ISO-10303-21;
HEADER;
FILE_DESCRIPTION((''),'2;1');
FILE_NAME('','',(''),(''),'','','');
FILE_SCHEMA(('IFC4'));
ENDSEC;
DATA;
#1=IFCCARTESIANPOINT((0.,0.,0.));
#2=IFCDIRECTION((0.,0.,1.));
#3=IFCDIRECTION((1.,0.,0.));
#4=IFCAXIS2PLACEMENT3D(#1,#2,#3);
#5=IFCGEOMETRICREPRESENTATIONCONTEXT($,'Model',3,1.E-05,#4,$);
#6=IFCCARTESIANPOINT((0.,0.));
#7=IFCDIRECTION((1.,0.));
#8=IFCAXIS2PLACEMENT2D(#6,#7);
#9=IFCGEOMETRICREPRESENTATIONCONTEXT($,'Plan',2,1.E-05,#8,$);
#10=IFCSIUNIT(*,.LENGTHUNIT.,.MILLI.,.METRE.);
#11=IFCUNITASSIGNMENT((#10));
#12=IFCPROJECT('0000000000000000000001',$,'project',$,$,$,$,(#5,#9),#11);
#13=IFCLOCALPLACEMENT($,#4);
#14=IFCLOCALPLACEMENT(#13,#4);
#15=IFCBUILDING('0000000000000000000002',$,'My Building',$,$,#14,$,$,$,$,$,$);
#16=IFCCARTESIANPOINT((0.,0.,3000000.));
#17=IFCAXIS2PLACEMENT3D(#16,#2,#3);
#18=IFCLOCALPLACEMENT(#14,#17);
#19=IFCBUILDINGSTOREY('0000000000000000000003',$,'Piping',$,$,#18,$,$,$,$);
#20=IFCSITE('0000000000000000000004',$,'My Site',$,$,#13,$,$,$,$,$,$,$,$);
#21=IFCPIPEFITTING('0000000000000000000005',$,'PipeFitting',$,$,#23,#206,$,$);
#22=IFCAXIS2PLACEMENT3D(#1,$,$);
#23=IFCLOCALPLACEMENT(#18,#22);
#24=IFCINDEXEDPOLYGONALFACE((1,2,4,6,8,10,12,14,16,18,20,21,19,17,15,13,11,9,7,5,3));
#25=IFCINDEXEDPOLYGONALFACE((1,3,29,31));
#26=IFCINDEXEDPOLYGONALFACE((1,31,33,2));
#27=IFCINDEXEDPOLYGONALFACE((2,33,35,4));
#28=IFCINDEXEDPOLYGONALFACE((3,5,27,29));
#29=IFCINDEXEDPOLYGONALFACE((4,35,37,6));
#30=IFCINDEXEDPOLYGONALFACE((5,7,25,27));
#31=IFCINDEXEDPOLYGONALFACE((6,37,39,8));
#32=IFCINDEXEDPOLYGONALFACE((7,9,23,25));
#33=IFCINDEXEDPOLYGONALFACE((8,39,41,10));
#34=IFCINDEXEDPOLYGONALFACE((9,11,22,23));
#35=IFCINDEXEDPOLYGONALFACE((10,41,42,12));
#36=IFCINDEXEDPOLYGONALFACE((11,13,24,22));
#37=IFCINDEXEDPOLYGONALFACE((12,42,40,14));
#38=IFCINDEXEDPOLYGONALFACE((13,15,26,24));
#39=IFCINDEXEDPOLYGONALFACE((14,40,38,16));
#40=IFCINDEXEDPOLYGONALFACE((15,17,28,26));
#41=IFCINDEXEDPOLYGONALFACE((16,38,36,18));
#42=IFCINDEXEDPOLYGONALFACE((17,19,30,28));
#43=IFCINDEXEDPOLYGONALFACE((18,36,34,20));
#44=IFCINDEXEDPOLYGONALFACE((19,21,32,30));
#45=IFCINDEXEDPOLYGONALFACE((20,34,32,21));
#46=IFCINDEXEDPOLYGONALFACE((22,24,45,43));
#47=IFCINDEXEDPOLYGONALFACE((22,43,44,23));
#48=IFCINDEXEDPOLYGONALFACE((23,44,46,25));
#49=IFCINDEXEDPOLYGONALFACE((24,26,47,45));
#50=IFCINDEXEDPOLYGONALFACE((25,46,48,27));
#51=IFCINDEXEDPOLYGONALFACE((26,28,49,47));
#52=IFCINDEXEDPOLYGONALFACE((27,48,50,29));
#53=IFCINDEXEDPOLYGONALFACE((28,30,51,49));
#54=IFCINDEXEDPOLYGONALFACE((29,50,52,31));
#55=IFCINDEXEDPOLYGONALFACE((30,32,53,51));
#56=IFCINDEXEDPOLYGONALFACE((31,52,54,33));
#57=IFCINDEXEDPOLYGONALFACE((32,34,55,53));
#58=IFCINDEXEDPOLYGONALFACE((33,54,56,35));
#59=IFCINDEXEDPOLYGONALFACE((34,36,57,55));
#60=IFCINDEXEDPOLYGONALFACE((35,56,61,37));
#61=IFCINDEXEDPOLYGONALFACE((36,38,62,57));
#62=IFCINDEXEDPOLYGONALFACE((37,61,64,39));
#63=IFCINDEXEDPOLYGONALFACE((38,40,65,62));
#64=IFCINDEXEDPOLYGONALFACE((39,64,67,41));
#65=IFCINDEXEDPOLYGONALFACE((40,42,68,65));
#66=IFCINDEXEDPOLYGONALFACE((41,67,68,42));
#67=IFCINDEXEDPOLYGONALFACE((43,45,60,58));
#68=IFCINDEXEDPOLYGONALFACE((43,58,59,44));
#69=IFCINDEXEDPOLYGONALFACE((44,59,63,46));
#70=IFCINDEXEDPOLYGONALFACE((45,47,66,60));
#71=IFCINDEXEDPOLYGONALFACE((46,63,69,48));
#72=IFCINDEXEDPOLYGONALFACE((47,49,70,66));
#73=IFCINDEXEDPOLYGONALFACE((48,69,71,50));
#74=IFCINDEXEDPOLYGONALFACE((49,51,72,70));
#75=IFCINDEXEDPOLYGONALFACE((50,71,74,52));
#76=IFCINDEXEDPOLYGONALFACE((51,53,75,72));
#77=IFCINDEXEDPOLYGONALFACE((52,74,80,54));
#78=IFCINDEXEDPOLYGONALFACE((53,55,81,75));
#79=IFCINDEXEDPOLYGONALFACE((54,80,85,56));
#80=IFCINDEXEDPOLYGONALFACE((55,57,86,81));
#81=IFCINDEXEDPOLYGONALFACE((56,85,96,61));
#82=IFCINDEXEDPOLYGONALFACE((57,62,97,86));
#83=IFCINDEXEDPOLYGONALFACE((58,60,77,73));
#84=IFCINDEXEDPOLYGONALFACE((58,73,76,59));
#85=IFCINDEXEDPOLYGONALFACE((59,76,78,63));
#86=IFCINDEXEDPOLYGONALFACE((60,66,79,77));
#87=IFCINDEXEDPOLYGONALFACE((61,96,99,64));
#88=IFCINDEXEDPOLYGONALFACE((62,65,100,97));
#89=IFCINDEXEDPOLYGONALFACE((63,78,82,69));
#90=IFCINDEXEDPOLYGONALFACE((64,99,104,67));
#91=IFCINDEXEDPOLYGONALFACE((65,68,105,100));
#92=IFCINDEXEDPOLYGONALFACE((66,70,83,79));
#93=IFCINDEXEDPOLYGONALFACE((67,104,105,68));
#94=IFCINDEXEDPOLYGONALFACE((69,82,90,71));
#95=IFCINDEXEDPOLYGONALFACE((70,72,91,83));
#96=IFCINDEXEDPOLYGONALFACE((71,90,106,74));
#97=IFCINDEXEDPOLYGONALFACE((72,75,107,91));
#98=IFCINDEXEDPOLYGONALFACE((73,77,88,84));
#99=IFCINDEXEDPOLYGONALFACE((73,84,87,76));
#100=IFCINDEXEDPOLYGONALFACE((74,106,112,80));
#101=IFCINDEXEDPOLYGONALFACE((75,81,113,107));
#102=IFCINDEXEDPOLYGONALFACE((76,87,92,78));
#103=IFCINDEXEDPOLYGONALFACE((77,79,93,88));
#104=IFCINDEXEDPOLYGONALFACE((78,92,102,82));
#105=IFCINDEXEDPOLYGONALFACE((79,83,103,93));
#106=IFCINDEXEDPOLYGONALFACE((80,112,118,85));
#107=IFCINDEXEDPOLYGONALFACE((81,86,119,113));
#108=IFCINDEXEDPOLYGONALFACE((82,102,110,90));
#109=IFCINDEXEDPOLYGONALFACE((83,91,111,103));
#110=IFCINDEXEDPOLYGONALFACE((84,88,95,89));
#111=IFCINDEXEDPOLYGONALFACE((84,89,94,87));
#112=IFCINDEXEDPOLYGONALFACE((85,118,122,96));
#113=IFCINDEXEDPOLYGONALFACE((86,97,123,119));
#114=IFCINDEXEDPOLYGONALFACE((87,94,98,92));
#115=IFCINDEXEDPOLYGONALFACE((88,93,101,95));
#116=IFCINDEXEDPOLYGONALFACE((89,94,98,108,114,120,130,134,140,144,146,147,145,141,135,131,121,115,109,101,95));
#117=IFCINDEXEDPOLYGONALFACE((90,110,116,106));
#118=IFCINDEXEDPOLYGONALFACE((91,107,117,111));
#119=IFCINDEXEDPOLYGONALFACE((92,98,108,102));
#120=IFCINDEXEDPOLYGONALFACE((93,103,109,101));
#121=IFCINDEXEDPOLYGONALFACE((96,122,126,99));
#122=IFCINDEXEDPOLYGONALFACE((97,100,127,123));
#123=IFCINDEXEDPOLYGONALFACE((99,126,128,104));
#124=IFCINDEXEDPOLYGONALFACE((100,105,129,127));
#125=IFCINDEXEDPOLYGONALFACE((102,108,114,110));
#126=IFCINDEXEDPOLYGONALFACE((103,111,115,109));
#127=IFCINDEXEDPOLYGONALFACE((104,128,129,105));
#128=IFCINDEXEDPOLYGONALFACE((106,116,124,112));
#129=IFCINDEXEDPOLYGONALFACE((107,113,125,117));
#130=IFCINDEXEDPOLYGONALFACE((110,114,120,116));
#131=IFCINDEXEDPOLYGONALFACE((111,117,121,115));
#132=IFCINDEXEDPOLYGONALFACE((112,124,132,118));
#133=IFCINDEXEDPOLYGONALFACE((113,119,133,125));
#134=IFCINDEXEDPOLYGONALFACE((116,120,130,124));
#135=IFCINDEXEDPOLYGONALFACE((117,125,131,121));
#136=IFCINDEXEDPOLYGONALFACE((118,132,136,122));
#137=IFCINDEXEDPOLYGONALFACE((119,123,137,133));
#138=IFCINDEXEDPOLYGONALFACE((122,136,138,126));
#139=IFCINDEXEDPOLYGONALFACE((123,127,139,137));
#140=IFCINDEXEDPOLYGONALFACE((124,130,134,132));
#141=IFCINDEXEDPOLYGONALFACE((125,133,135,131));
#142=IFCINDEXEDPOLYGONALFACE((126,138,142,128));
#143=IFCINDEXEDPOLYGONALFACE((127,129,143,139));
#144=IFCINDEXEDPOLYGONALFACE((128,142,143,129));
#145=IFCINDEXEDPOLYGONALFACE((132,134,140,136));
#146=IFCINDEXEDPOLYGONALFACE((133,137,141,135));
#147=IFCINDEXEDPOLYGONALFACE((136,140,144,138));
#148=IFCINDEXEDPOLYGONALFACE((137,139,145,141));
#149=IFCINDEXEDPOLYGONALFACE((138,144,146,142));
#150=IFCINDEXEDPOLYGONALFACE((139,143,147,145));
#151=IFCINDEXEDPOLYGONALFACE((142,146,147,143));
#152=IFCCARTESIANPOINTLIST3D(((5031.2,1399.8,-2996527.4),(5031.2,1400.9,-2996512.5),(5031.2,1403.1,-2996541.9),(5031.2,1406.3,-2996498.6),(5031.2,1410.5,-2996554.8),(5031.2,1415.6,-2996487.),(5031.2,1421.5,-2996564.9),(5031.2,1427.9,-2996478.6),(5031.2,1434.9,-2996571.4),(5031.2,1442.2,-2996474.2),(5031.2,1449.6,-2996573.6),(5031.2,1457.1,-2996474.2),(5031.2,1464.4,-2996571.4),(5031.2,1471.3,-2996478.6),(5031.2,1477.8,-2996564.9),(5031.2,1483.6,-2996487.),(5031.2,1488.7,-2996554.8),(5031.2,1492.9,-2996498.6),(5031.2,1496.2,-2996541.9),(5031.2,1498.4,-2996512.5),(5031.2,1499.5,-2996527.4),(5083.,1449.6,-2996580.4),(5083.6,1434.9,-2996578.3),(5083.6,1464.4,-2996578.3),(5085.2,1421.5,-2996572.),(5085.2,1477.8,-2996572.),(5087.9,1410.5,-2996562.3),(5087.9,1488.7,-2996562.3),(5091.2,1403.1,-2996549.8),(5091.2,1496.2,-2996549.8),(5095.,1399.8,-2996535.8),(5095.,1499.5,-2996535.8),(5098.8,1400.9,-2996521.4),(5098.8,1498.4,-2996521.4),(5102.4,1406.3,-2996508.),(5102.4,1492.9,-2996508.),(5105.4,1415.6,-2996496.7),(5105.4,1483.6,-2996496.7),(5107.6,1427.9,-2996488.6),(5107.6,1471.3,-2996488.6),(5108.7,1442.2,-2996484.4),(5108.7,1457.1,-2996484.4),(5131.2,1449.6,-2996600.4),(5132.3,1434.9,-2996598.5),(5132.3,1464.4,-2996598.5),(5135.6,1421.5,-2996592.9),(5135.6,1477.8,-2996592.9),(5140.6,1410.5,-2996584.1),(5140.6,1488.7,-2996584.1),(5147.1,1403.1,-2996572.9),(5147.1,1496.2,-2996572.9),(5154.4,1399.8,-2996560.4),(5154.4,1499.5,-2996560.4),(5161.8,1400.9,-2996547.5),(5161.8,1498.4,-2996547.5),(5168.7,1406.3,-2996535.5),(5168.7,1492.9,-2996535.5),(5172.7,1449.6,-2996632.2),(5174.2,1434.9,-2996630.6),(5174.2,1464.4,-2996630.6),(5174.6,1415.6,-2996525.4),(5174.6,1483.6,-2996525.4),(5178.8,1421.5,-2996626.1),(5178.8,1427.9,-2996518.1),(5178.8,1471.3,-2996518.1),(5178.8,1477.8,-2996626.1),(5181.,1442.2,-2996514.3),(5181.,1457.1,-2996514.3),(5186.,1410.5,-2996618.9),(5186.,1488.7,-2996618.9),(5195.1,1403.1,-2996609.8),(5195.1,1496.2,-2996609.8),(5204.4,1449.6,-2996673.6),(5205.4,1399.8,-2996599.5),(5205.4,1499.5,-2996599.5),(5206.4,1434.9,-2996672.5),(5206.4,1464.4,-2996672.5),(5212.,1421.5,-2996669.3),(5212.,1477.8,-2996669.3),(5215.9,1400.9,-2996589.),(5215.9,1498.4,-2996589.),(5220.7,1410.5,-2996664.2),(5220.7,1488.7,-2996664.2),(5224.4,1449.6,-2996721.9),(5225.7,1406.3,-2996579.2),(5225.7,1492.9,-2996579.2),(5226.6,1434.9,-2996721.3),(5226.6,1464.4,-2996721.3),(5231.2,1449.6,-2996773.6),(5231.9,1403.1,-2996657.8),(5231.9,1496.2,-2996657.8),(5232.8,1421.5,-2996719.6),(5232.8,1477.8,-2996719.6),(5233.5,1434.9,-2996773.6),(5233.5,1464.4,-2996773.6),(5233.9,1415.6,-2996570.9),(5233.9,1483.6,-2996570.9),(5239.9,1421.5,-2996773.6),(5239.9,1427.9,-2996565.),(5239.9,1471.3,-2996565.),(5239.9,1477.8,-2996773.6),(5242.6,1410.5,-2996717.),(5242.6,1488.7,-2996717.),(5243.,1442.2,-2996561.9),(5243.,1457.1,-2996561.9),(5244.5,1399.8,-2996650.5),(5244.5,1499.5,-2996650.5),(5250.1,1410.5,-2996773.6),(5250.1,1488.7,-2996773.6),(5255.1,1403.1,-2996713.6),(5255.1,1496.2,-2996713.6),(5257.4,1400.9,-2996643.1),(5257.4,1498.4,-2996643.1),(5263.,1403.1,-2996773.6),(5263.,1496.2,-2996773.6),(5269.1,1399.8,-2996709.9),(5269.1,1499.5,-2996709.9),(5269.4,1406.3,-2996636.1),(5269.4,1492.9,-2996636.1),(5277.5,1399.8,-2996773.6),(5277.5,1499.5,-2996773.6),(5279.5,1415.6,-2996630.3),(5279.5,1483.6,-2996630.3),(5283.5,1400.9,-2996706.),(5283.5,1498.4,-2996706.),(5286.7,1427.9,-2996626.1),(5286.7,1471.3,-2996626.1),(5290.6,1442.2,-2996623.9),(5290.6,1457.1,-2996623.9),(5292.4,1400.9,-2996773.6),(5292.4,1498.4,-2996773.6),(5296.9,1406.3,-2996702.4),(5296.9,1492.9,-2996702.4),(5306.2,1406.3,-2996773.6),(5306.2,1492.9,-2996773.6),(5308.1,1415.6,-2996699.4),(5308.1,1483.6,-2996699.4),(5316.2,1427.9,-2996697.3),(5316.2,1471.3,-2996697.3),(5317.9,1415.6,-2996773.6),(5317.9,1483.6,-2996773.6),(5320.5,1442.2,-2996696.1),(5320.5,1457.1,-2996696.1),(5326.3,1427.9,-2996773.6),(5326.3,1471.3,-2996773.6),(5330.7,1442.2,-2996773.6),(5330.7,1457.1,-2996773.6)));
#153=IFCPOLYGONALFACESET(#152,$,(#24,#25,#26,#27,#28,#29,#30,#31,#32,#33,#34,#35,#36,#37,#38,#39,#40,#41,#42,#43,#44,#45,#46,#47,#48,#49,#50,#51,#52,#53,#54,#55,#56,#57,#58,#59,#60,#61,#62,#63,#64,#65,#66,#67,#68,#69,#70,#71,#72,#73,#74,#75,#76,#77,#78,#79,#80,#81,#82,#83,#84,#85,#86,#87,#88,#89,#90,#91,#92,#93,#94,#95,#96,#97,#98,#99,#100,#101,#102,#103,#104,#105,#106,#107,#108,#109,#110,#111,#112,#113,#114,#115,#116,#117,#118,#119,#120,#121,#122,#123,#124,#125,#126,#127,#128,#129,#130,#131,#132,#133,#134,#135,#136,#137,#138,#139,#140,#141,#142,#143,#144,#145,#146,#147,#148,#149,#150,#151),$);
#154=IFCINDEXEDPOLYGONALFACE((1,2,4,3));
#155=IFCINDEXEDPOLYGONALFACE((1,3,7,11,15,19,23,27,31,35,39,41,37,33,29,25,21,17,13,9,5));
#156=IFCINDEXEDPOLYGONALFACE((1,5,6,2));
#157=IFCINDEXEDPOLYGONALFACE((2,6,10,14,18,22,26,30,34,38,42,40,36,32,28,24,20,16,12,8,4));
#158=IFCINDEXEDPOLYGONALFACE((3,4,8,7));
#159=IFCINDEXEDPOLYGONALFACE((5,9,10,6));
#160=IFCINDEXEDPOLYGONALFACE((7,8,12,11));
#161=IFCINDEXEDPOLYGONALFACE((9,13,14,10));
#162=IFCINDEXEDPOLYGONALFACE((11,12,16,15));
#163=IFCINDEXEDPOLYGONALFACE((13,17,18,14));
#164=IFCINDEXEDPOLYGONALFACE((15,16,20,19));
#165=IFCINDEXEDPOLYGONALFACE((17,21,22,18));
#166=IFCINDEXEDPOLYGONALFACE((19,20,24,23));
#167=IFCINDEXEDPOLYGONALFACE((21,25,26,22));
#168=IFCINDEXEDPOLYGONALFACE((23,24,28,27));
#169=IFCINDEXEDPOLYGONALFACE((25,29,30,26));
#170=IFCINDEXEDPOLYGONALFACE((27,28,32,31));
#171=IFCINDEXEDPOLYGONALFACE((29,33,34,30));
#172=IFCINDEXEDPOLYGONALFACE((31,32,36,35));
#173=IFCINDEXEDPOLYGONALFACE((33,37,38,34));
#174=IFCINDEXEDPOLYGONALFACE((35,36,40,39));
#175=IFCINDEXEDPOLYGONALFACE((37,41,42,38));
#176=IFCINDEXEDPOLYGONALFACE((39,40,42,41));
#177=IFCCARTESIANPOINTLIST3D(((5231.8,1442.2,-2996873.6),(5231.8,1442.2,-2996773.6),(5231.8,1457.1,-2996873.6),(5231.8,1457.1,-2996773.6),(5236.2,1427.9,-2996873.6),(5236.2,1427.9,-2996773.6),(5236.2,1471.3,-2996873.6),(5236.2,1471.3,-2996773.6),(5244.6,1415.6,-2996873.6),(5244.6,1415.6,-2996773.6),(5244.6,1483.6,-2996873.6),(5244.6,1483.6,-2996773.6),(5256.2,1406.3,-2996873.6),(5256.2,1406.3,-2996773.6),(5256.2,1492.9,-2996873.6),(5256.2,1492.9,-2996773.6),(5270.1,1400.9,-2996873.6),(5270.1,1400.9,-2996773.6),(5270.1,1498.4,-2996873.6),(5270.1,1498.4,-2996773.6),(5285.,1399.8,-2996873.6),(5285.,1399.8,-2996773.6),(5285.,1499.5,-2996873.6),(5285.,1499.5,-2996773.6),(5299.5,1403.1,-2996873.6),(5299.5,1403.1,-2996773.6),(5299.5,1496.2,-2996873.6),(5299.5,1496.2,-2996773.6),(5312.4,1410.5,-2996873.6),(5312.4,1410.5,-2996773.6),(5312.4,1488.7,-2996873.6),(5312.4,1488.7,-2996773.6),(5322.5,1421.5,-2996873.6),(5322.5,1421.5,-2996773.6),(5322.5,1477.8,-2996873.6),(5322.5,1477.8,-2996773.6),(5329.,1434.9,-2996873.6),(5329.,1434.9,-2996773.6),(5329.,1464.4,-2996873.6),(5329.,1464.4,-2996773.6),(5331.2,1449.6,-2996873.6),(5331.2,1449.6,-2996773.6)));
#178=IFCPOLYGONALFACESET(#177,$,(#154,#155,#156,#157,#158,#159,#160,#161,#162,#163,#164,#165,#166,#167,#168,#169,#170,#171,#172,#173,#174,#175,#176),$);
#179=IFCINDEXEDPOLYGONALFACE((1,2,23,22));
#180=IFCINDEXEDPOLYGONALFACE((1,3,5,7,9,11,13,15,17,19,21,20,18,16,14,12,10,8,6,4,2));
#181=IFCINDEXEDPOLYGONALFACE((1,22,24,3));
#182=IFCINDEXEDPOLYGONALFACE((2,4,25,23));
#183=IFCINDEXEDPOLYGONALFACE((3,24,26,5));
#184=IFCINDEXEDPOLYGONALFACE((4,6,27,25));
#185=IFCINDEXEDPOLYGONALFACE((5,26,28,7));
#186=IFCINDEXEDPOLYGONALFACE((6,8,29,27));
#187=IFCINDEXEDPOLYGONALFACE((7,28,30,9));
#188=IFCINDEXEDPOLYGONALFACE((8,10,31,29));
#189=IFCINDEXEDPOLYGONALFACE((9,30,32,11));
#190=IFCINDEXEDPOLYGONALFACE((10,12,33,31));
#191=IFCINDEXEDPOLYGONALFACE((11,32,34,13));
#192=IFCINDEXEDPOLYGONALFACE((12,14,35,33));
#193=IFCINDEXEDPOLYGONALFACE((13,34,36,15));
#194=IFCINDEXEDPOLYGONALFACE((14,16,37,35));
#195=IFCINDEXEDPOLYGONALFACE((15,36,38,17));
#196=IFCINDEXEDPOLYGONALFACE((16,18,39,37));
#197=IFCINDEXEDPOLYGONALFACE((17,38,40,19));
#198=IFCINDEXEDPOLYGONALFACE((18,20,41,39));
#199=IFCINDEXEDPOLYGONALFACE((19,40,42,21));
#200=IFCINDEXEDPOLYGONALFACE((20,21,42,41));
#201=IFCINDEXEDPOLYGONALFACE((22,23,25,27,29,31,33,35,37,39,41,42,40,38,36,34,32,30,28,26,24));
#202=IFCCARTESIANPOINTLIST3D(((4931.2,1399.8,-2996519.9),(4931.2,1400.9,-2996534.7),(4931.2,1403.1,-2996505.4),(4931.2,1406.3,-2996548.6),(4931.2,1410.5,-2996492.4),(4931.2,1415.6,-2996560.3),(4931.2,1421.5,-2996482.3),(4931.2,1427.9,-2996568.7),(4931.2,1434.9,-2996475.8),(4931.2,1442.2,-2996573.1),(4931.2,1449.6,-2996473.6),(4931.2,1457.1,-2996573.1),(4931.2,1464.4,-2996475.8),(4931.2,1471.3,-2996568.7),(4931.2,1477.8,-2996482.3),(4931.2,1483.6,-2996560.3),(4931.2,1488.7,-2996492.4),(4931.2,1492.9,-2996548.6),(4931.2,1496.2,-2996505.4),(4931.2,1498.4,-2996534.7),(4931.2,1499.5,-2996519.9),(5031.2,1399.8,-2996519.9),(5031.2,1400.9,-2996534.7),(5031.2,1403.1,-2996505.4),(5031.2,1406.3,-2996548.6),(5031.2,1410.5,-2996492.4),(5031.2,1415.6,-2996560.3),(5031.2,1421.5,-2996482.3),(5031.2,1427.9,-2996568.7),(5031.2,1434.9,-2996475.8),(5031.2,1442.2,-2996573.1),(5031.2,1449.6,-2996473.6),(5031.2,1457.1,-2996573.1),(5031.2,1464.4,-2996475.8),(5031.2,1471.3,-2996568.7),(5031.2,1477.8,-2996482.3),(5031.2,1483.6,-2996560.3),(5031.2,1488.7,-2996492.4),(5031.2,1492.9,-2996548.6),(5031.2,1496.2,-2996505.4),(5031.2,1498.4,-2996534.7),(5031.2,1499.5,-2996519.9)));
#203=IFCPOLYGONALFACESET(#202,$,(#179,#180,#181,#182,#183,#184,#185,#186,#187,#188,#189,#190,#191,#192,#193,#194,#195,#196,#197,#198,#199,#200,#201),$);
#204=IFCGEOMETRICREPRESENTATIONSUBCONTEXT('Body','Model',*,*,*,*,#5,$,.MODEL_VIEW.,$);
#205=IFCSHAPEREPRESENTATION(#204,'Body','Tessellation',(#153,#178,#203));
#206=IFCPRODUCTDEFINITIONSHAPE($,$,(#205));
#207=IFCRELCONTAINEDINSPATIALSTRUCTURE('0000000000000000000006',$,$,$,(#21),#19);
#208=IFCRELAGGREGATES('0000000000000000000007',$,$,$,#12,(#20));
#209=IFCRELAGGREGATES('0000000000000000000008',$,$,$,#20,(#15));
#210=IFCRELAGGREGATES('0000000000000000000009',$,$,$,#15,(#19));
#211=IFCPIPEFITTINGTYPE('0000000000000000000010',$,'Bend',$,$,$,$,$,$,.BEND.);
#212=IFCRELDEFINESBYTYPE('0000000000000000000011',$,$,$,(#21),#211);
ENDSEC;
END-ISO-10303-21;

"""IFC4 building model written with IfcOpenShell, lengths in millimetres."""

from ifc_helpers import new_model, entity, si_unit, frame, origin_with_axes, origin_2d_with_axis, place, context, subcontext, project, spatial, circle, extrude, source, transform, mapped, type_object, type_shapes, element, save


model = new_model("IFC4")

# Units and contexts
model_context = context("Model", 3, precision=1e-05, world=origin_with_axes())
plan_context = context("Plan", 2, precision=1e-05, world=origin_2d_with_axis())
body_context = subcontext(model_context, "Body", "Model", "MODEL_VIEW")
ifc_project = project(units=[si_unit("LENGTHUNIT", "METRE", prefix="MILLI")], contexts=[model_context, plan_context])

# Site, building, storey
site_placement = place(None, origin_with_axes())
site = spatial("IfcSite", under=ifc_project, at=site_placement, Name="My Site")
building_placement = place(site_placement, origin_with_axes())
building = spatial("IfcBuilding", under=site, at=building_placement, Name="My Building")
storey_placement = place(building_placement, frame((0.0, 0.0, 3000000.0), z_axis=(0.0, 0.0, 1.0), x_axis=(1.0, 0.0, 0.0)))
storey = spatial("IfcBuildingStorey", under=building, at=storey_placement, Name="Piping")

# Shared definitions
pipe_fitting_type_1 = type_object("IfcPipeFittingType", Name="Bend", PredefinedType="BEND")
shared_shape_1 = source(origin_with_axes(), body_context, "Body", "SolidModel", [
    entity("IfcSweptDiskSolid", entity("IfcIndexedPolyCurve", entity("IfcCartesianPointList3D", [[0.0, 0.0, -100.0], [-73.2, 0.0, -276.8], [-250.0, 0.0, -350.0]]), [entity("IfcArcIndex", [1, 2, 3])]), 50.0),
    extrude(circle(Radius=50.0), origin_with_axes(), (0.0, 0.0, -1.0), 100.0),
    extrude(circle(Radius=50.0), frame((-250.0, 0.0, -350.0), z_axis=(-1.0, 0.0, 0.0), x_axis=(0.0, 0.0, -1.0)), (0.0, 0.0, 1.0), 100.0),
])
type_shapes(pipe_fitting_type_1, [shared_shape_1])

# Pipe fitting
for number, where, z_axis, x_axis, name in (
    (1, (5281.2, 1449.6, -2996873.6), (0.0, 0.0, -1.0), (1.0, 0.0, 0.0), "PipeFitting"),
):
    element("IfcPipeFitting", number, at=place(storey_placement, frame(where, z_axis=z_axis, x_axis=x_axis)), inside=storey, type_object=pipe_fitting_type_1, Name=name, context=body_context, shape_type="MappedRepresentation", body=[
        mapped(shared_shape_1, transform((0.0, 0.0, 0.0), x_axis=(1.0, 0.0, 0.0), y_axis=(0.0, 1.0, 0.0), z_axis=(0.0, 0.0, 1.0), scale=1.0)),
    ])

save(model, "model.ifc")
